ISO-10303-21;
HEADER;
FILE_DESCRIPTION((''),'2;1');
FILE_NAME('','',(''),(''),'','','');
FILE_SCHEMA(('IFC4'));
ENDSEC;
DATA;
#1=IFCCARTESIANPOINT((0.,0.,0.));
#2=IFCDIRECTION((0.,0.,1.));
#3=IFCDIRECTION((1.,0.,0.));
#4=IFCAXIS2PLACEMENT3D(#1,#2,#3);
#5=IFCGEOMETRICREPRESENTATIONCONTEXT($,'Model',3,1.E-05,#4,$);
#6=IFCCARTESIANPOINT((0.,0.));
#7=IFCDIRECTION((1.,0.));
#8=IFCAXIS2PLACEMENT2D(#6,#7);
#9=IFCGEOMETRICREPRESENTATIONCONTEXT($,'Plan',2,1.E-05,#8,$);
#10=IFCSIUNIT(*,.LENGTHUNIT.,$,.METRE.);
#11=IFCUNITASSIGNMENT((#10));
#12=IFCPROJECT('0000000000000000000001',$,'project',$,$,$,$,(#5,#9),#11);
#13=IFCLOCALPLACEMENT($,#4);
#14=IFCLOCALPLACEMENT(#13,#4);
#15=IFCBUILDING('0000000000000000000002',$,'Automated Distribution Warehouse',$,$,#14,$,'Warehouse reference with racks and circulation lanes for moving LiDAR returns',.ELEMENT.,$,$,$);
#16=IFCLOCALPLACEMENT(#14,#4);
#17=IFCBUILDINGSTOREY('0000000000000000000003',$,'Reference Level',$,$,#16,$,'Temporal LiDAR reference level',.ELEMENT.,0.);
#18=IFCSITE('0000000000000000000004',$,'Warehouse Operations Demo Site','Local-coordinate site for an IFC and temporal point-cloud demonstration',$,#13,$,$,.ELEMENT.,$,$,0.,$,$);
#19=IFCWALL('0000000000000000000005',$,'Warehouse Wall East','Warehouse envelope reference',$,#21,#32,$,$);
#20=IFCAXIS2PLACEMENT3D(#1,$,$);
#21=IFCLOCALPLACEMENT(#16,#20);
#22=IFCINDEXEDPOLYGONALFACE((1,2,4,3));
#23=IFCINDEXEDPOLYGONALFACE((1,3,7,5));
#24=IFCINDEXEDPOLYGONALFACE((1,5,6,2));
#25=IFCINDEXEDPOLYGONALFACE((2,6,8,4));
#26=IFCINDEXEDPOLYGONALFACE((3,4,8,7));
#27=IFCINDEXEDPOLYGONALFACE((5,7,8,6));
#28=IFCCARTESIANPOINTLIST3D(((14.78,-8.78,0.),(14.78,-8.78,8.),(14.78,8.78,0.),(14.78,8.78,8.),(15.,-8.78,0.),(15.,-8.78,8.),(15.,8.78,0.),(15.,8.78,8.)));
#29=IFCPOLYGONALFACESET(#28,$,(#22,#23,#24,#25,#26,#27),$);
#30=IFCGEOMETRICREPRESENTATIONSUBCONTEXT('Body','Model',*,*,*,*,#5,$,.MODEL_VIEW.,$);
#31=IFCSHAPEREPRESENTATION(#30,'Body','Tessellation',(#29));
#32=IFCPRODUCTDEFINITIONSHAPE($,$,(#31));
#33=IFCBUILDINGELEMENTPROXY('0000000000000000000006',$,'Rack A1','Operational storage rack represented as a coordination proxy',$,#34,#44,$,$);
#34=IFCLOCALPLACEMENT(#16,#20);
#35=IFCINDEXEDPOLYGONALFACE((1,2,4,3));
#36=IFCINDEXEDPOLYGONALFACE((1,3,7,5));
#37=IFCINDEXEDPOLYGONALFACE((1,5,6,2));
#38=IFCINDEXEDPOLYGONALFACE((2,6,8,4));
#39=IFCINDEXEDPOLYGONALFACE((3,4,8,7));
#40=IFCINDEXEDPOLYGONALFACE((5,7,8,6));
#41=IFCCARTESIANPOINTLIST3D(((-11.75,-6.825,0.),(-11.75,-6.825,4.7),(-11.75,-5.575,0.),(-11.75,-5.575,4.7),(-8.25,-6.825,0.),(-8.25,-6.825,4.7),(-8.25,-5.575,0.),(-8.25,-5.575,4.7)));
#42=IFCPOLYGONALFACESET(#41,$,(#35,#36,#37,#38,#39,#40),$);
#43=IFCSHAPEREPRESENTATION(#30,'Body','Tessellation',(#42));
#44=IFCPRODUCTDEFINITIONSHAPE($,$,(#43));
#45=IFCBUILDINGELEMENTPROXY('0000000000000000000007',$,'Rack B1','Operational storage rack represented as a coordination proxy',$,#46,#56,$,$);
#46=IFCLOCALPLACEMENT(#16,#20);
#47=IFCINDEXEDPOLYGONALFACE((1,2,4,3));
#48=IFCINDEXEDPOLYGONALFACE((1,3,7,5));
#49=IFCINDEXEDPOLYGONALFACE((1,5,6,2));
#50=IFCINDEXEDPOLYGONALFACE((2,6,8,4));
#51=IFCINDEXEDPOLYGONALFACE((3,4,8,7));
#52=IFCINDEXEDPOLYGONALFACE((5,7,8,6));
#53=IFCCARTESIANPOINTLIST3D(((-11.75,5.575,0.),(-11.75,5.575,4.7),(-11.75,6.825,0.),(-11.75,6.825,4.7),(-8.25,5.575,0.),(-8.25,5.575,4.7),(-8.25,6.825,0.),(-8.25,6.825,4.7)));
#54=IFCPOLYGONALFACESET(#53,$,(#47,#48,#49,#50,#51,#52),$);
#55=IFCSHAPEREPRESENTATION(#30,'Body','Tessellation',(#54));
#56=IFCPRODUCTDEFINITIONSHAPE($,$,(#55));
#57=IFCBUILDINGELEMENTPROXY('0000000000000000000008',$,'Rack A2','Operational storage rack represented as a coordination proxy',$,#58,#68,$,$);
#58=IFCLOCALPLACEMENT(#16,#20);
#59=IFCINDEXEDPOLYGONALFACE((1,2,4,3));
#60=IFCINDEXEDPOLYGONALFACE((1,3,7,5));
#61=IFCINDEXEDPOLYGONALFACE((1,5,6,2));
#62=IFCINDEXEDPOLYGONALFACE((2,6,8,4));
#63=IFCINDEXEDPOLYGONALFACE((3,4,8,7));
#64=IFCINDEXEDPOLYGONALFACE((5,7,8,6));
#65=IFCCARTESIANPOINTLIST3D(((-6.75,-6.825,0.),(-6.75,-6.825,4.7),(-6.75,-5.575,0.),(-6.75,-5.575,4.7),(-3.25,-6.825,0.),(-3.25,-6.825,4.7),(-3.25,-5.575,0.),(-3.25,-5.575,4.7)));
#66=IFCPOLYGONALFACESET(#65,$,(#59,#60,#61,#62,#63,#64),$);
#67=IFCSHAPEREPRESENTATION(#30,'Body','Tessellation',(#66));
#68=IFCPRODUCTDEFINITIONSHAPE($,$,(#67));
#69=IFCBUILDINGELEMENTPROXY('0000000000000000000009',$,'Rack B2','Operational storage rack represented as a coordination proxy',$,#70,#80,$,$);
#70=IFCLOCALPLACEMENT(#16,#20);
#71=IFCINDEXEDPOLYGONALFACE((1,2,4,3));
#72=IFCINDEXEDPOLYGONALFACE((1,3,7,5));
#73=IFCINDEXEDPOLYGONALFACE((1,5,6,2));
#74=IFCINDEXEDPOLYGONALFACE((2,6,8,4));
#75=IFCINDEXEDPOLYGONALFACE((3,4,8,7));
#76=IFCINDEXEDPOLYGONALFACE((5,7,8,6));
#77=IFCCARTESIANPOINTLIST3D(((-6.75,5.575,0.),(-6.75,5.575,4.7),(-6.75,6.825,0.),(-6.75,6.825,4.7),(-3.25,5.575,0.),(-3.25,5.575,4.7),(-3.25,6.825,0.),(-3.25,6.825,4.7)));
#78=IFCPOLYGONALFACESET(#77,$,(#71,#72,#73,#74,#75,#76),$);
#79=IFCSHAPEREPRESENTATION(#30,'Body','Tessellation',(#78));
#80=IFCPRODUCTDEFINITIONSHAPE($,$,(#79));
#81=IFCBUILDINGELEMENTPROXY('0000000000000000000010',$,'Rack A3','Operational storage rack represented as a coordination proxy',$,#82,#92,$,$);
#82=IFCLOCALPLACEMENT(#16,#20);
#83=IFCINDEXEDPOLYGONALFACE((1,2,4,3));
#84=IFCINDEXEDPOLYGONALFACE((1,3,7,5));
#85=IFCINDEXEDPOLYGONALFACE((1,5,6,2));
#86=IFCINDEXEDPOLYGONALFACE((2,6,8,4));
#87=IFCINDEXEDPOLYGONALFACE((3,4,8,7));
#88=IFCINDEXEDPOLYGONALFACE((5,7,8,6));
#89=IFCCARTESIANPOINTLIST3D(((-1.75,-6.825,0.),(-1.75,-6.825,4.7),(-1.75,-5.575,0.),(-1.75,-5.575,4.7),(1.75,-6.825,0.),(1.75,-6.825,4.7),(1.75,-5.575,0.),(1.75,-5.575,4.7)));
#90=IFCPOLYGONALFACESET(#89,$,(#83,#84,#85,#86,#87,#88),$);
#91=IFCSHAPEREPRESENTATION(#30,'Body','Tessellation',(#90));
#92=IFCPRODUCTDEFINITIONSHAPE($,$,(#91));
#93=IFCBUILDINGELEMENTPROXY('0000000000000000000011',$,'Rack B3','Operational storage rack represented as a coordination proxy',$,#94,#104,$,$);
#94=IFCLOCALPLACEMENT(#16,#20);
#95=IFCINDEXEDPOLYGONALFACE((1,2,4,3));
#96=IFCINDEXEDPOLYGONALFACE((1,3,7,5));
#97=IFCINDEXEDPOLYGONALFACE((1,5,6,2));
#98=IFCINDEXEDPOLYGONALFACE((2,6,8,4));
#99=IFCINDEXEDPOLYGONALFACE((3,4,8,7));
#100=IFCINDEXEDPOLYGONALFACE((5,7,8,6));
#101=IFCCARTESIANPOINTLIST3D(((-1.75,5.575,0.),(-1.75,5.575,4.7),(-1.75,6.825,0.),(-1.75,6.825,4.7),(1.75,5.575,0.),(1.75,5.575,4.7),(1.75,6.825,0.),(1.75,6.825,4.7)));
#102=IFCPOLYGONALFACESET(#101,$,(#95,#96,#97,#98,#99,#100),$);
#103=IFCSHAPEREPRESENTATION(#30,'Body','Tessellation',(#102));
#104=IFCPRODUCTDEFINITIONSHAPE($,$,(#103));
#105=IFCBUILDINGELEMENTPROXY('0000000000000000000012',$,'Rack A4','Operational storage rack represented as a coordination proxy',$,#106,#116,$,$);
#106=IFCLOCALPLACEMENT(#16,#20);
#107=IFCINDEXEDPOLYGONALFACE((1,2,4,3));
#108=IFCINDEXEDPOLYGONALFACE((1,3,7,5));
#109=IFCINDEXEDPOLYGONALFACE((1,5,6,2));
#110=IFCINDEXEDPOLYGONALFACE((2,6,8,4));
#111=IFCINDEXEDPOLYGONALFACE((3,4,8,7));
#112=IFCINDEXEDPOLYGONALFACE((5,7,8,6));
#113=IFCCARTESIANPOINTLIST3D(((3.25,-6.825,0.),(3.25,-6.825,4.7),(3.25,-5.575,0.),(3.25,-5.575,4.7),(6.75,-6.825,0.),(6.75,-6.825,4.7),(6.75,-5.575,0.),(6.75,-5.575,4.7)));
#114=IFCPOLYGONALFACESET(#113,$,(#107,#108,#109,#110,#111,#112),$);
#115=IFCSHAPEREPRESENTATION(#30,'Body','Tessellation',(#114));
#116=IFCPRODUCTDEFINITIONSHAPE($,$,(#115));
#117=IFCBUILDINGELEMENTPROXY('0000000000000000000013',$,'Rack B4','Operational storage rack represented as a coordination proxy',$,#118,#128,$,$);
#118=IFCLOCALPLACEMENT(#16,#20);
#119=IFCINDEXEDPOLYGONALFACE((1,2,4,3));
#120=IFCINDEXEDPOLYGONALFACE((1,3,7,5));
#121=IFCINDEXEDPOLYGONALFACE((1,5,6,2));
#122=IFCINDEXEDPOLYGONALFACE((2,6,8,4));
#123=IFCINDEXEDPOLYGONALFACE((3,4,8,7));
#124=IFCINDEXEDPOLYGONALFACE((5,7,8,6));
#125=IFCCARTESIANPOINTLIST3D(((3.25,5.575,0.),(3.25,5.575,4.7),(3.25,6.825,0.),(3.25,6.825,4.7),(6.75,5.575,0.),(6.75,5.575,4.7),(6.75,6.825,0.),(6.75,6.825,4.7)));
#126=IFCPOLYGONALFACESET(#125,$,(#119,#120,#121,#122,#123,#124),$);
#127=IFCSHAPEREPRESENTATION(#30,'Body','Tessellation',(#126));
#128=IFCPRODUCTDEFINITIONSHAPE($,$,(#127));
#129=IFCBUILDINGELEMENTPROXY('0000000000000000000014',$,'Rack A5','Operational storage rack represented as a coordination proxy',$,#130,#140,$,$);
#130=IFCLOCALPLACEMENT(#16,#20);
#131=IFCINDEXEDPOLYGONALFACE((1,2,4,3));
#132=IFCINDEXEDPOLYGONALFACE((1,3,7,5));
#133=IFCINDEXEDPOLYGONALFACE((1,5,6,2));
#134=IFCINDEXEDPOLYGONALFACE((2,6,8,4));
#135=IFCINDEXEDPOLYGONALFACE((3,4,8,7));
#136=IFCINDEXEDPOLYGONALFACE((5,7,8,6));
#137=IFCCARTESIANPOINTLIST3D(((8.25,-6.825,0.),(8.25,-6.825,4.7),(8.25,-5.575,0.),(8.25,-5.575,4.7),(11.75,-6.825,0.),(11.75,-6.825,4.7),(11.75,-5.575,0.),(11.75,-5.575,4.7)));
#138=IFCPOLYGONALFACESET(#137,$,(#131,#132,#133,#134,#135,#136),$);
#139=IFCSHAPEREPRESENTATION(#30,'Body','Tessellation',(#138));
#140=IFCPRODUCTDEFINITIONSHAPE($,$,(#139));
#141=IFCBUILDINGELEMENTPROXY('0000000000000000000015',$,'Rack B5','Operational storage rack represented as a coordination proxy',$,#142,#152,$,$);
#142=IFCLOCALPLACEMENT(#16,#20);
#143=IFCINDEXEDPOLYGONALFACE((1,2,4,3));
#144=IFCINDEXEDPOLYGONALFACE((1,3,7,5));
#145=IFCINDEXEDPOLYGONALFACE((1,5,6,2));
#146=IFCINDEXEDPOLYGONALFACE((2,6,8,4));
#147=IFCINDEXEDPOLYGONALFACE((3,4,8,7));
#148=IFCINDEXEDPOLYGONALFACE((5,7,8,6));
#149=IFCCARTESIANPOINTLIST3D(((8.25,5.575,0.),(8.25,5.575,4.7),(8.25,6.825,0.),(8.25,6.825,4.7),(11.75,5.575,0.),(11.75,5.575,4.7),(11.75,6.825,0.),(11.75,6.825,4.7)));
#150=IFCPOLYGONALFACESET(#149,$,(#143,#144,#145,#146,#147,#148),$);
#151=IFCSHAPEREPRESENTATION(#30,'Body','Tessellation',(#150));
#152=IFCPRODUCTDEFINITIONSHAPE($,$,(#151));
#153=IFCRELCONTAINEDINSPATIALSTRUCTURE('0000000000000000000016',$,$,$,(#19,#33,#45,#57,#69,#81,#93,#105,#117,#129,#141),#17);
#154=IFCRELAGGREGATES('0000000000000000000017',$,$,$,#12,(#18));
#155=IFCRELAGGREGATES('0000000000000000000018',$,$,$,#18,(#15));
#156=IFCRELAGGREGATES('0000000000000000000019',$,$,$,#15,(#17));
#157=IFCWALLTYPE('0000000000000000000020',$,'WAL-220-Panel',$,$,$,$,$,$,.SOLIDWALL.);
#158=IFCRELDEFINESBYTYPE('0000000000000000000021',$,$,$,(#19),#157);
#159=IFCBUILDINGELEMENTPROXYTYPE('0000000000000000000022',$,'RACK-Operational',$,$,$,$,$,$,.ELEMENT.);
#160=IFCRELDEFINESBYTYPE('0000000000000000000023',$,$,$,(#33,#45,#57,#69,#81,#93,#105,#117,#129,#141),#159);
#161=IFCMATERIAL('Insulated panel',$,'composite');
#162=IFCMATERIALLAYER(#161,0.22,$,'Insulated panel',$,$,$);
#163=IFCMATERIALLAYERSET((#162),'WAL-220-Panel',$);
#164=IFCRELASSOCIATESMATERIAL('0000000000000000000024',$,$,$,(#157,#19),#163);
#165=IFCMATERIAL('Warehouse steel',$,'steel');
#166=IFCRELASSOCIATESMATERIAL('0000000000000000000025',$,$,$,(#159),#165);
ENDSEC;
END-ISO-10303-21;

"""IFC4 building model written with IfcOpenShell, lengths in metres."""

from ifc_helpers import new_model, si_unit, frame, origin_with_axes, origin_2d_with_axis, place, context, subcontext, project, spatial, line, indexed_curve, outline, extrude, material, layer, layer_set, layer_usage, type_object, element, save


model = new_model("IFC4")

# Units and contexts
model_context = context("Model", 3, precision=1e-05, world=origin_with_axes())
plan_context = context("Plan", 2, precision=1e-05, world=origin_2d_with_axis())
body_context = subcontext(model_context, "Body", "Model", "MODEL_VIEW")
ifc_project = project(units=[si_unit("LENGTHUNIT", "METRE")], contexts=[model_context, plan_context])

# Site, building, storey
site_placement = place(None, origin_with_axes())
site = spatial("IfcSite", under=ifc_project, at=site_placement, Name="Warehouse Operations Demo Site", Description="Local-coordinate site for an IFC and temporal point-cloud demonstration", CompositionType="ELEMENT", RefElevation=0.0)
building_placement = place(site_placement, origin_with_axes())
building = spatial("IfcBuilding", under=site, at=building_placement, Name="Automated Distribution Warehouse", LongName="Warehouse reference with racks and circulation lanes for moving LiDAR returns", CompositionType="ELEMENT")
storey_placement = place(building_placement, origin_with_axes())
storey = spatial("IfcBuildingStorey", under=building, at=storey_placement, Name="Reference Level", LongName="Temporal LiDAR reference level", CompositionType="ELEMENT", Elevation=0.0)

# Shared definitions
ifc_material_1 = material(Name="Warehouse steel", Category="steel")

# Shared definitions
ifc_material_2 = material(Name="Insulated panel", Category="composite")

# Wall
ifc_layer_1 = layer(ifc_material_2, 0.22, Name="Insulated panel")
ifc_layer_set_1 = layer_set([ifc_layer_1], Name="WAL-220-Panel")
wall_type = type_object("IfcWallType", Name="WAL-220-Panel", PredefinedType="SOLIDWALL", material=ifc_layer_set_1)
ifc_layer_usage_1 = layer_usage(ifc_layer_set_1, "AXIS2", "POSITIVE", 0.0)
wall_1_placement = place(storey_placement, frame((14.78, -8.78, 0.0), z_axis=(0.0, 0.0, 1.0), x_axis=(1.0, 0.0, 0.0)))
element("IfcWall", 1, at=wall_1_placement, inside=storey, type_object=wall_type, material=ifc_layer_usage_1, Name="Warehouse Wall East", Description="Warehouse envelope reference", context=body_context, shape_type="SweptSolid", body=[
    extrude(outline(indexed_curve([(0.0, 0.0), (0.22, 0.0), (0.22, 17.56), (0.0, 17.56)], segments=[line(1, 2, 3, 4, 1)])), origin_with_axes(), (0.0, 0.0, 1.0), 8.0),
])

# Building element proxies
building_element_proxy_type = type_object("IfcBuildingElementProxyType", Name="RACK-Operational", PredefinedType="ELEMENT", material=ifc_material_1)
for number, where, z_axis, x_axis, name in (
    (2, (-11.75, -6.825, 0.0), (0.0, 0.0, 1.0), (1.0, 0.0, 0.0), "Rack A1"),
    (3, (-11.75, 5.575, 0.0), (0.0, 0.0, 1.0), (1.0, 0.0, 0.0), "Rack B1"),
    (4, (-6.75, -6.825, 0.0), (0.0, 0.0, 1.0), (1.0, 0.0, 0.0), "Rack A2"),
    (5, (-6.75, 5.575, 0.0), (0.0, 0.0, 1.0), (1.0, 0.0, 0.0), "Rack B2"),
    (6, (-1.75, -6.825, 0.0), (0.0, 0.0, 1.0), (1.0, 0.0, 0.0), "Rack A3"),
    (7, (-1.75, 5.575, 0.0), (0.0, 0.0, 1.0), (1.0, 0.0, 0.0), "Rack B3"),
    (8, (3.25, -6.825, 0.0), (0.0, 0.0, 1.0), (1.0, 0.0, 0.0), "Rack A4"),
    (9, (3.25, 5.575, 0.0), (0.0, 0.0, 1.0), (1.0, 0.0, 0.0), "Rack B4"),
    (10, (8.25, -6.825, 0.0), (0.0, 0.0, 1.0), (1.0, 0.0, 0.0), "Rack A5"),
    (11, (8.25, 5.575, 0.0), (0.0, 0.0, 1.0), (1.0, 0.0, 0.0), "Rack B5"),
):
    element("IfcBuildingElementProxy", number, at=place(storey_placement, frame(where, z_axis=z_axis, x_axis=x_axis)), inside=storey, type_object=building_element_proxy_type, Name=name, Description="Operational storage rack represented as a coordination proxy", context=body_context, shape_type="SweptSolid", body=[
        extrude(outline(indexed_curve([(0.0, 0.0), (3.5, 0.0), (3.5, 1.25), (0.0, 1.25)], segments=[line(1, 2, 3, 4, 1)])), origin_with_axes(), (0.0, 0.0, 1.0), 4.7),
    ])

save(model, "model.ifc")
